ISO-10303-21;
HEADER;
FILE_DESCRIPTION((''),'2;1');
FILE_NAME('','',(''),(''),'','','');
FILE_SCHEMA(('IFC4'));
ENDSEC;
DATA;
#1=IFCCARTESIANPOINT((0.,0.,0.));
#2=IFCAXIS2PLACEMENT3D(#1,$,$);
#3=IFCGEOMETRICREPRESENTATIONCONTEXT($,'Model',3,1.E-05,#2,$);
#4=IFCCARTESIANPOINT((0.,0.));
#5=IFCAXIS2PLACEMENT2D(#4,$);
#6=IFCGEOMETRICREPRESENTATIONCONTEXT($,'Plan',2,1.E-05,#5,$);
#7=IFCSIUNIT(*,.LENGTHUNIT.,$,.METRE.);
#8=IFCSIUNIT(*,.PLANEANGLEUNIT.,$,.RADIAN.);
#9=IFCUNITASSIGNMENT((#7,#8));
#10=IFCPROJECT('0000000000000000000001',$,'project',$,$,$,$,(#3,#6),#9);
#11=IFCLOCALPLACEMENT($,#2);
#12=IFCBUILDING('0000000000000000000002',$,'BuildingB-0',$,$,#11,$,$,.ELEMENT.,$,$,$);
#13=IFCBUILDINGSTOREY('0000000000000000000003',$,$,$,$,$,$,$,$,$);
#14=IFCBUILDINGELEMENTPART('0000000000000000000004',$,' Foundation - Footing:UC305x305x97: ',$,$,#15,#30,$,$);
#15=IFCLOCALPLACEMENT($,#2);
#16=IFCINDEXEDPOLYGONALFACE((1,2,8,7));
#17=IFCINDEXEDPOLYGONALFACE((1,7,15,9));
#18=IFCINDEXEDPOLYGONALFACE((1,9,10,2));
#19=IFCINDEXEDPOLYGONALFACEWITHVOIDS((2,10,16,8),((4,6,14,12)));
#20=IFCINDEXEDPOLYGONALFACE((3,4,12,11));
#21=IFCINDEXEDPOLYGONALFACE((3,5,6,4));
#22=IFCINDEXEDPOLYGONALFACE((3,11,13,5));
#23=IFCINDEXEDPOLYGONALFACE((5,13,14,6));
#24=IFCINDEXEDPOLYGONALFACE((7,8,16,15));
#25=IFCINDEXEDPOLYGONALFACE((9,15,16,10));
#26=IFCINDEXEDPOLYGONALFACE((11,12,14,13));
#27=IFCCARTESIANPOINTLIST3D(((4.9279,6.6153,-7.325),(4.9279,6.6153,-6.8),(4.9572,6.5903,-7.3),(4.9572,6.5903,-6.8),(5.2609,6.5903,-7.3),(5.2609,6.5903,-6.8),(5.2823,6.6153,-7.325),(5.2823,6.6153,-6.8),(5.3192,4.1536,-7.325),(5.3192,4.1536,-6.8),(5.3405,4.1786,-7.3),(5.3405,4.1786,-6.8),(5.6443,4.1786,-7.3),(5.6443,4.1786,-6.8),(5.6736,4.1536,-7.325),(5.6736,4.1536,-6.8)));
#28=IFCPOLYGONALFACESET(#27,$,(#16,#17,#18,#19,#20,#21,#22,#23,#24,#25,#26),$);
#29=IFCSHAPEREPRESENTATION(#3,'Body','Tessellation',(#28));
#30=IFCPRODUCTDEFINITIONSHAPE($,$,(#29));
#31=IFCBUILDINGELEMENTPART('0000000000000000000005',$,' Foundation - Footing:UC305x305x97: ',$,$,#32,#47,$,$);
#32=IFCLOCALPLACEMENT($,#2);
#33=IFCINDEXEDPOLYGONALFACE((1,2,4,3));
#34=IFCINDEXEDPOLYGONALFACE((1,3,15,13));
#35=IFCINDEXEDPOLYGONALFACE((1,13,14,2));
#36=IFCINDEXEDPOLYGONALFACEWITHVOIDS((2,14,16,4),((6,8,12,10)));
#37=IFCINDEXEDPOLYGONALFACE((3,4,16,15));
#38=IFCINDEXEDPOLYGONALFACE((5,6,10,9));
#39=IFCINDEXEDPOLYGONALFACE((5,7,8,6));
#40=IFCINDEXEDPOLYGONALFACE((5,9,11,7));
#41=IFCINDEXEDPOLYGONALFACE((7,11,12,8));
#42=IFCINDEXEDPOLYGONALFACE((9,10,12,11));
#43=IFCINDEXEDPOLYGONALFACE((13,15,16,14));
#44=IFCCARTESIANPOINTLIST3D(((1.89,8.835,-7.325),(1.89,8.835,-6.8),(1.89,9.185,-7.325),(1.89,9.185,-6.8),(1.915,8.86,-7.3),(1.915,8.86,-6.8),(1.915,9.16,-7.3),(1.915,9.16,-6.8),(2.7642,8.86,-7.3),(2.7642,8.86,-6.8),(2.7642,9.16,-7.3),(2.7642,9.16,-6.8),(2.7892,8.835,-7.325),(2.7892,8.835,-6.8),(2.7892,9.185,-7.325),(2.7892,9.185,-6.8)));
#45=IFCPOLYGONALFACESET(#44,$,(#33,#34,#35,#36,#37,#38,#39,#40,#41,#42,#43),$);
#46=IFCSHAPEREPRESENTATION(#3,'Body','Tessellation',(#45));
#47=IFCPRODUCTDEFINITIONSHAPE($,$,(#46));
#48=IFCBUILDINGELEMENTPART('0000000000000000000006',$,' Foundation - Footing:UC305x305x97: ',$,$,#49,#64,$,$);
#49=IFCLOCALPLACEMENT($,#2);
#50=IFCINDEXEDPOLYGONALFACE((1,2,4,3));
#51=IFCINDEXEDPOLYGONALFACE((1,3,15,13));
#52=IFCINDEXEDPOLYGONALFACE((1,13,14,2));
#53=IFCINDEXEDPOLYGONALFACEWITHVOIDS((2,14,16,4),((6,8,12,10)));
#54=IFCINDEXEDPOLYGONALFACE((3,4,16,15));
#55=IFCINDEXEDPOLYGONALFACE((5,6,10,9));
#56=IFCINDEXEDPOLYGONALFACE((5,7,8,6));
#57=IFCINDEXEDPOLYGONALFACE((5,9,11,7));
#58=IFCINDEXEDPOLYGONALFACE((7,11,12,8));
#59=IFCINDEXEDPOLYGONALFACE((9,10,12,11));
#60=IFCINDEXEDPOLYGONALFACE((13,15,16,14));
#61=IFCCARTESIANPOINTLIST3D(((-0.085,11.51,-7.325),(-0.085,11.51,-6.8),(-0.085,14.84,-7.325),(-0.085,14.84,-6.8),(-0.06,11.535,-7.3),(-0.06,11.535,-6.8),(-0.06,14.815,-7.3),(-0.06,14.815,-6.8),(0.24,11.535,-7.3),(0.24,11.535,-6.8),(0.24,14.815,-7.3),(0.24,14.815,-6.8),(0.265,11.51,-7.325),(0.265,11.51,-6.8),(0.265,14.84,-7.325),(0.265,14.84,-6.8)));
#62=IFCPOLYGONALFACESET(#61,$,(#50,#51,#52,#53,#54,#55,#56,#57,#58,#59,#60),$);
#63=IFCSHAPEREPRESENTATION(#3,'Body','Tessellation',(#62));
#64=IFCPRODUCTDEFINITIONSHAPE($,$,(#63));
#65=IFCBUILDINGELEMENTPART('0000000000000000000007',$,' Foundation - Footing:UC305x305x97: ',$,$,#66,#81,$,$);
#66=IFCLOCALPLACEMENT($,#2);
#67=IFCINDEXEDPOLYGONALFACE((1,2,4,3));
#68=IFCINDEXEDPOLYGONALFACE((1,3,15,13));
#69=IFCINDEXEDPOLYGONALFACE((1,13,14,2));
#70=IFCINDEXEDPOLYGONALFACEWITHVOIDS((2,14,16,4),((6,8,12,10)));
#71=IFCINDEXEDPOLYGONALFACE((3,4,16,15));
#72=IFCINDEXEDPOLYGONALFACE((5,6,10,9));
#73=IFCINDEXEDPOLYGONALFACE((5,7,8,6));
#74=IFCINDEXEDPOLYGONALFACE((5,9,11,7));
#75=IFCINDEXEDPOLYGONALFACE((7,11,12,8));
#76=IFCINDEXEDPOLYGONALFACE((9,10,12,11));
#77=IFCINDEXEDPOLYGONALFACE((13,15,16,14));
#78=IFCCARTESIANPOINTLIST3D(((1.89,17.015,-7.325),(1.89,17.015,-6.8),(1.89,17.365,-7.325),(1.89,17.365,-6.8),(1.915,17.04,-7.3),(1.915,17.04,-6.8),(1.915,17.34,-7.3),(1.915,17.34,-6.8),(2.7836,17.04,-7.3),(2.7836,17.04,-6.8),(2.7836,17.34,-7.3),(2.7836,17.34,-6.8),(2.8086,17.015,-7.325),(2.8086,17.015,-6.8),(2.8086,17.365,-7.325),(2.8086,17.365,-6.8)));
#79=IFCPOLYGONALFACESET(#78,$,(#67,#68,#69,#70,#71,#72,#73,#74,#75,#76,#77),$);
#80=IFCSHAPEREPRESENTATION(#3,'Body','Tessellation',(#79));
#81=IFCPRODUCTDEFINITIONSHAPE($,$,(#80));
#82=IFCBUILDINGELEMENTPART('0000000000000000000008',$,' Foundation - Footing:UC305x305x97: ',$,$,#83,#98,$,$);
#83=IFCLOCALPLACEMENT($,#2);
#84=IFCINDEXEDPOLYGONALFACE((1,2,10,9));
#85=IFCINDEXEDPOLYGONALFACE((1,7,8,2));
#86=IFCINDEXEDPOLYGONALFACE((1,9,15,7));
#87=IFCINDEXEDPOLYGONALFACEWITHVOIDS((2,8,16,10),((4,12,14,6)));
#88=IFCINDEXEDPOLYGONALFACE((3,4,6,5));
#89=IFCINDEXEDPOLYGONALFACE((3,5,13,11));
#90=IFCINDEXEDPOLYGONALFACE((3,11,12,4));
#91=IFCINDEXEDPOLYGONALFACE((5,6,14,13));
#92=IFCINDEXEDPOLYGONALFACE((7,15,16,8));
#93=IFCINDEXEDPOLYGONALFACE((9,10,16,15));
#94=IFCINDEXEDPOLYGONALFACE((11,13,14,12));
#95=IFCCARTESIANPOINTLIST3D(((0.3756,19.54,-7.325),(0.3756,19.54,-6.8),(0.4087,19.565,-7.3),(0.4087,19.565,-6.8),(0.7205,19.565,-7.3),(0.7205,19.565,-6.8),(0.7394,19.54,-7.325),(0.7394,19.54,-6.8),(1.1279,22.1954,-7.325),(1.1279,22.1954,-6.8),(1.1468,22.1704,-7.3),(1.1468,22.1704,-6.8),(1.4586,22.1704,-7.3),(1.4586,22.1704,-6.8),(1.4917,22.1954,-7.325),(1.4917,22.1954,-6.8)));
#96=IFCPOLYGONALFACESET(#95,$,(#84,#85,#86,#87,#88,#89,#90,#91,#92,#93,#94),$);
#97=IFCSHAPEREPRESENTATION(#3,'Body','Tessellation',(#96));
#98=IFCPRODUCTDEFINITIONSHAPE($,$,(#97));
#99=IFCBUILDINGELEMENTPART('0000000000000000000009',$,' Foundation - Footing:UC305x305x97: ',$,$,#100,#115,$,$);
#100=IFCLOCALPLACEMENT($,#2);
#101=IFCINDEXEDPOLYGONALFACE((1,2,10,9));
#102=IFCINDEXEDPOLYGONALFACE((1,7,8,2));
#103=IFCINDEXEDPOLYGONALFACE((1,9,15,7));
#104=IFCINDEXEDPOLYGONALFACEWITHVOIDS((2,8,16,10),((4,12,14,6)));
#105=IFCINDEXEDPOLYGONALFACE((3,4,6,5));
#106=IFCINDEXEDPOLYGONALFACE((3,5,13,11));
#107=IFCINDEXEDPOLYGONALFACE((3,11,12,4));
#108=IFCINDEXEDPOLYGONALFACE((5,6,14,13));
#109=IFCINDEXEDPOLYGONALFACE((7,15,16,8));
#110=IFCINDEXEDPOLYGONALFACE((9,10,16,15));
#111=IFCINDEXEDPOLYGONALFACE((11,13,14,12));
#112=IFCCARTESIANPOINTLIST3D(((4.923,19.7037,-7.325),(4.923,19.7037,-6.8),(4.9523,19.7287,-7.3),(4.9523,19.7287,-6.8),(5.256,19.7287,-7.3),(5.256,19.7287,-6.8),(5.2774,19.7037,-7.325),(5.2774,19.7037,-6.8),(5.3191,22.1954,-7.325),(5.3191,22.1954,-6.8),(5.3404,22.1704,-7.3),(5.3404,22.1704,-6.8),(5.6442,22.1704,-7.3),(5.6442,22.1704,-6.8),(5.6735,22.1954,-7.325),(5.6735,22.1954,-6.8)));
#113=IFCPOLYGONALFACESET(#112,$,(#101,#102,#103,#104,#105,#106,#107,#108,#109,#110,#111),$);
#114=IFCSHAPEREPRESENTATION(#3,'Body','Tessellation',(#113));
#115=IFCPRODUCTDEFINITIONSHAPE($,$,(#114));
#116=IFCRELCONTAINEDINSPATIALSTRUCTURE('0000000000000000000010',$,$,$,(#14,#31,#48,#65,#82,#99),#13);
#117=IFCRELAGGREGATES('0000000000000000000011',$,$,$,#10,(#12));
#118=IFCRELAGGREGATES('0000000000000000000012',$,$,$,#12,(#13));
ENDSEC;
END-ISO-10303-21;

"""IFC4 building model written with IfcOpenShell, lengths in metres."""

from ifc_helpers import new_model, si_unit, origin, origin_2d, place, context, project, spatial, polyline, outline, extrude, element, save


model = new_model("IFC4")

# Units and contexts
model_context = context("Model", 3, precision=1e-05, world=origin())
plan_context = context("Plan", 2, precision=1e-05, world=origin_2d())
ifc_project = project(units=[si_unit("LENGTHUNIT", "METRE"), si_unit("PLANEANGLEUNIT", "RADIAN")], contexts=[model_context, plan_context])

# Building, storey
building_placement = place(None, origin())
building = spatial("IfcBuilding", under=ifc_project, at=building_placement, Name="BuildingB-0", CompositionType="ELEMENT")
storey = spatial("IfcBuildingStorey", under=building)

# Building element parts, openings
building_element_part_1 = element("IfcBuildingElementPart", 1, inside=storey, Name=" Foundation - Footing:UC305x305x97: ", context=model_context, shape_type="SweptSolid", body=[
    extrude(outline(polyline([(5.3192, 4.1536, -7.325), (4.9279, 6.6153, -7.325), (5.2823, 6.6153, -7.325), (5.6736, 4.1536, -7.325), (5.3192, 4.1536, -7.325)])), None, (0.0, 0.0, 1.0), 0.525),
])
element("IfcOpeningElement", 2, inside=storey, cuts=building_element_part_1, context=model_context, shape_type="SweptSolid", body=[
    extrude(outline(polyline([(5.3405, 4.1786, -7.3), (4.9572, 6.5903, -7.3), (5.2609, 6.5903, -7.3), (5.6443, 4.1786, -7.3), (5.3405, 4.1786, -7.3)])), None, (0.0, 0.0, 1.0), 0.5),
])
building_element_part_2 = element("IfcBuildingElementPart", 3, inside=storey, Name=" Foundation - Footing:UC305x305x97: ", context=model_context, shape_type="SweptSolid", body=[
    extrude(outline(polyline([(1.89, 8.835, -7.325), (1.89, 9.185, -7.325), (2.7892, 9.185, -7.325), (2.7892, 8.835, -7.325), (1.89, 8.835, -7.325)])), None, (0.0, 0.0, 1.0), 0.525),
])
element("IfcOpeningElement", 4, inside=storey, cuts=building_element_part_2, context=model_context, shape_type="SweptSolid", body=[
    extrude(outline(polyline([(1.915, 8.86, -7.3), (1.915, 9.16, -7.3), (2.7642, 9.16, -7.3), (2.7642, 8.86, -7.3), (1.915, 8.86, -7.3)])), None, (0.0, 0.0, 1.0), 0.5),
])
building_element_part_3 = element("IfcBuildingElementPart", 5, inside=storey, Name=" Foundation - Footing:UC305x305x97: ", context=model_context, shape_type="SweptSolid", body=[
    extrude(outline(polyline([(-0.085, 11.51, -7.325), (-0.085, 14.84, -7.325), (0.265, 14.84, -7.325), (0.265, 11.51, -7.325), (-0.085, 11.51, -7.325)])), None, (0.0, 0.0, 1.0), 0.525),
])
element("IfcOpeningElement", 6, inside=storey, cuts=building_element_part_3, context=model_context, shape_type="SweptSolid", body=[
    extrude(outline(polyline([(-0.06, 11.535, -7.3), (-0.06, 14.815, -7.3), (0.24, 14.815, -7.3), (0.24, 11.535, -7.3), (-0.06, 11.535, -7.3)])), None, (0.0, 0.0, 1.0), 0.5),
])
building_element_part_4 = element("IfcBuildingElementPart", 7, inside=storey, Name=" Foundation - Footing:UC305x305x97: ", context=model_context, shape_type="SweptSolid", body=[
    extrude(outline(polyline([(1.89, 17.015, -7.325), (1.89, 17.365, -7.325), (2.8086, 17.365, -7.325), (2.8086, 17.015, -7.325), (1.89, 17.015, -7.325)])), None, (0.0, 0.0, 1.0), 0.525),
])
element("IfcOpeningElement", 8, inside=storey, cuts=building_element_part_4, context=model_context, shape_type="SweptSolid", body=[
    extrude(outline(polyline([(1.915, 17.04, -7.3), (1.915, 17.34, -7.3), (2.7836, 17.34, -7.3), (2.7836, 17.04, -7.3), (1.915, 17.04, -7.3)])), None, (0.0, 0.0, 1.0), 0.5),
])
building_element_part_5 = element("IfcBuildingElementPart", 9, inside=storey, Name=" Foundation - Footing:UC305x305x97: ", context=model_context, shape_type="SweptSolid", body=[
    extrude(outline(polyline([(0.3756, 19.54, -7.325), (1.1279, 22.1954, -7.325), (1.4917, 22.1954, -7.325), (0.7394, 19.54, -7.325), (0.3756, 19.54, -7.325)])), None, (0.0, 0.0, 1.0), 0.525),
])
element("IfcOpeningElement", 10, inside=storey, cuts=building_element_part_5, context=model_context, shape_type="SweptSolid", body=[
    extrude(outline(polyline([(0.4087, 19.565, -7.3), (1.1468, 22.1704, -7.3), (1.4586, 22.1704, -7.3), (0.7205, 19.565, -7.3), (0.4087, 19.565, -7.3)])), None, (0.0, 0.0, 1.0), 0.5),
])
building_element_part_6 = element("IfcBuildingElementPart", 11, inside=storey, Name=" Foundation - Footing:UC305x305x97: ", context=model_context, shape_type="SweptSolid", body=[
    extrude(outline(polyline([(5.2774, 19.7037, -7.325), (4.923, 19.7037, -7.325), (5.3191, 22.1954, -7.325), (5.6735, 22.1954, -7.325), (5.2774, 19.7037, -7.325)])), None, (0.0, 0.0, 1.0), 0.525),
])
element("IfcOpeningElement", 12, inside=storey, cuts=building_element_part_6, context=model_context, shape_type="SweptSolid", body=[
    extrude(outline(polyline([(5.256, 19.7287, -7.3), (4.9523, 19.7287, -7.3), (5.3404, 22.1704, -7.3), (5.6442, 22.1704, -7.3), (5.256, 19.7287, -7.3)])), None, (0.0, 0.0, 1.0), 0.5),
])

save(model, "model.ifc")
